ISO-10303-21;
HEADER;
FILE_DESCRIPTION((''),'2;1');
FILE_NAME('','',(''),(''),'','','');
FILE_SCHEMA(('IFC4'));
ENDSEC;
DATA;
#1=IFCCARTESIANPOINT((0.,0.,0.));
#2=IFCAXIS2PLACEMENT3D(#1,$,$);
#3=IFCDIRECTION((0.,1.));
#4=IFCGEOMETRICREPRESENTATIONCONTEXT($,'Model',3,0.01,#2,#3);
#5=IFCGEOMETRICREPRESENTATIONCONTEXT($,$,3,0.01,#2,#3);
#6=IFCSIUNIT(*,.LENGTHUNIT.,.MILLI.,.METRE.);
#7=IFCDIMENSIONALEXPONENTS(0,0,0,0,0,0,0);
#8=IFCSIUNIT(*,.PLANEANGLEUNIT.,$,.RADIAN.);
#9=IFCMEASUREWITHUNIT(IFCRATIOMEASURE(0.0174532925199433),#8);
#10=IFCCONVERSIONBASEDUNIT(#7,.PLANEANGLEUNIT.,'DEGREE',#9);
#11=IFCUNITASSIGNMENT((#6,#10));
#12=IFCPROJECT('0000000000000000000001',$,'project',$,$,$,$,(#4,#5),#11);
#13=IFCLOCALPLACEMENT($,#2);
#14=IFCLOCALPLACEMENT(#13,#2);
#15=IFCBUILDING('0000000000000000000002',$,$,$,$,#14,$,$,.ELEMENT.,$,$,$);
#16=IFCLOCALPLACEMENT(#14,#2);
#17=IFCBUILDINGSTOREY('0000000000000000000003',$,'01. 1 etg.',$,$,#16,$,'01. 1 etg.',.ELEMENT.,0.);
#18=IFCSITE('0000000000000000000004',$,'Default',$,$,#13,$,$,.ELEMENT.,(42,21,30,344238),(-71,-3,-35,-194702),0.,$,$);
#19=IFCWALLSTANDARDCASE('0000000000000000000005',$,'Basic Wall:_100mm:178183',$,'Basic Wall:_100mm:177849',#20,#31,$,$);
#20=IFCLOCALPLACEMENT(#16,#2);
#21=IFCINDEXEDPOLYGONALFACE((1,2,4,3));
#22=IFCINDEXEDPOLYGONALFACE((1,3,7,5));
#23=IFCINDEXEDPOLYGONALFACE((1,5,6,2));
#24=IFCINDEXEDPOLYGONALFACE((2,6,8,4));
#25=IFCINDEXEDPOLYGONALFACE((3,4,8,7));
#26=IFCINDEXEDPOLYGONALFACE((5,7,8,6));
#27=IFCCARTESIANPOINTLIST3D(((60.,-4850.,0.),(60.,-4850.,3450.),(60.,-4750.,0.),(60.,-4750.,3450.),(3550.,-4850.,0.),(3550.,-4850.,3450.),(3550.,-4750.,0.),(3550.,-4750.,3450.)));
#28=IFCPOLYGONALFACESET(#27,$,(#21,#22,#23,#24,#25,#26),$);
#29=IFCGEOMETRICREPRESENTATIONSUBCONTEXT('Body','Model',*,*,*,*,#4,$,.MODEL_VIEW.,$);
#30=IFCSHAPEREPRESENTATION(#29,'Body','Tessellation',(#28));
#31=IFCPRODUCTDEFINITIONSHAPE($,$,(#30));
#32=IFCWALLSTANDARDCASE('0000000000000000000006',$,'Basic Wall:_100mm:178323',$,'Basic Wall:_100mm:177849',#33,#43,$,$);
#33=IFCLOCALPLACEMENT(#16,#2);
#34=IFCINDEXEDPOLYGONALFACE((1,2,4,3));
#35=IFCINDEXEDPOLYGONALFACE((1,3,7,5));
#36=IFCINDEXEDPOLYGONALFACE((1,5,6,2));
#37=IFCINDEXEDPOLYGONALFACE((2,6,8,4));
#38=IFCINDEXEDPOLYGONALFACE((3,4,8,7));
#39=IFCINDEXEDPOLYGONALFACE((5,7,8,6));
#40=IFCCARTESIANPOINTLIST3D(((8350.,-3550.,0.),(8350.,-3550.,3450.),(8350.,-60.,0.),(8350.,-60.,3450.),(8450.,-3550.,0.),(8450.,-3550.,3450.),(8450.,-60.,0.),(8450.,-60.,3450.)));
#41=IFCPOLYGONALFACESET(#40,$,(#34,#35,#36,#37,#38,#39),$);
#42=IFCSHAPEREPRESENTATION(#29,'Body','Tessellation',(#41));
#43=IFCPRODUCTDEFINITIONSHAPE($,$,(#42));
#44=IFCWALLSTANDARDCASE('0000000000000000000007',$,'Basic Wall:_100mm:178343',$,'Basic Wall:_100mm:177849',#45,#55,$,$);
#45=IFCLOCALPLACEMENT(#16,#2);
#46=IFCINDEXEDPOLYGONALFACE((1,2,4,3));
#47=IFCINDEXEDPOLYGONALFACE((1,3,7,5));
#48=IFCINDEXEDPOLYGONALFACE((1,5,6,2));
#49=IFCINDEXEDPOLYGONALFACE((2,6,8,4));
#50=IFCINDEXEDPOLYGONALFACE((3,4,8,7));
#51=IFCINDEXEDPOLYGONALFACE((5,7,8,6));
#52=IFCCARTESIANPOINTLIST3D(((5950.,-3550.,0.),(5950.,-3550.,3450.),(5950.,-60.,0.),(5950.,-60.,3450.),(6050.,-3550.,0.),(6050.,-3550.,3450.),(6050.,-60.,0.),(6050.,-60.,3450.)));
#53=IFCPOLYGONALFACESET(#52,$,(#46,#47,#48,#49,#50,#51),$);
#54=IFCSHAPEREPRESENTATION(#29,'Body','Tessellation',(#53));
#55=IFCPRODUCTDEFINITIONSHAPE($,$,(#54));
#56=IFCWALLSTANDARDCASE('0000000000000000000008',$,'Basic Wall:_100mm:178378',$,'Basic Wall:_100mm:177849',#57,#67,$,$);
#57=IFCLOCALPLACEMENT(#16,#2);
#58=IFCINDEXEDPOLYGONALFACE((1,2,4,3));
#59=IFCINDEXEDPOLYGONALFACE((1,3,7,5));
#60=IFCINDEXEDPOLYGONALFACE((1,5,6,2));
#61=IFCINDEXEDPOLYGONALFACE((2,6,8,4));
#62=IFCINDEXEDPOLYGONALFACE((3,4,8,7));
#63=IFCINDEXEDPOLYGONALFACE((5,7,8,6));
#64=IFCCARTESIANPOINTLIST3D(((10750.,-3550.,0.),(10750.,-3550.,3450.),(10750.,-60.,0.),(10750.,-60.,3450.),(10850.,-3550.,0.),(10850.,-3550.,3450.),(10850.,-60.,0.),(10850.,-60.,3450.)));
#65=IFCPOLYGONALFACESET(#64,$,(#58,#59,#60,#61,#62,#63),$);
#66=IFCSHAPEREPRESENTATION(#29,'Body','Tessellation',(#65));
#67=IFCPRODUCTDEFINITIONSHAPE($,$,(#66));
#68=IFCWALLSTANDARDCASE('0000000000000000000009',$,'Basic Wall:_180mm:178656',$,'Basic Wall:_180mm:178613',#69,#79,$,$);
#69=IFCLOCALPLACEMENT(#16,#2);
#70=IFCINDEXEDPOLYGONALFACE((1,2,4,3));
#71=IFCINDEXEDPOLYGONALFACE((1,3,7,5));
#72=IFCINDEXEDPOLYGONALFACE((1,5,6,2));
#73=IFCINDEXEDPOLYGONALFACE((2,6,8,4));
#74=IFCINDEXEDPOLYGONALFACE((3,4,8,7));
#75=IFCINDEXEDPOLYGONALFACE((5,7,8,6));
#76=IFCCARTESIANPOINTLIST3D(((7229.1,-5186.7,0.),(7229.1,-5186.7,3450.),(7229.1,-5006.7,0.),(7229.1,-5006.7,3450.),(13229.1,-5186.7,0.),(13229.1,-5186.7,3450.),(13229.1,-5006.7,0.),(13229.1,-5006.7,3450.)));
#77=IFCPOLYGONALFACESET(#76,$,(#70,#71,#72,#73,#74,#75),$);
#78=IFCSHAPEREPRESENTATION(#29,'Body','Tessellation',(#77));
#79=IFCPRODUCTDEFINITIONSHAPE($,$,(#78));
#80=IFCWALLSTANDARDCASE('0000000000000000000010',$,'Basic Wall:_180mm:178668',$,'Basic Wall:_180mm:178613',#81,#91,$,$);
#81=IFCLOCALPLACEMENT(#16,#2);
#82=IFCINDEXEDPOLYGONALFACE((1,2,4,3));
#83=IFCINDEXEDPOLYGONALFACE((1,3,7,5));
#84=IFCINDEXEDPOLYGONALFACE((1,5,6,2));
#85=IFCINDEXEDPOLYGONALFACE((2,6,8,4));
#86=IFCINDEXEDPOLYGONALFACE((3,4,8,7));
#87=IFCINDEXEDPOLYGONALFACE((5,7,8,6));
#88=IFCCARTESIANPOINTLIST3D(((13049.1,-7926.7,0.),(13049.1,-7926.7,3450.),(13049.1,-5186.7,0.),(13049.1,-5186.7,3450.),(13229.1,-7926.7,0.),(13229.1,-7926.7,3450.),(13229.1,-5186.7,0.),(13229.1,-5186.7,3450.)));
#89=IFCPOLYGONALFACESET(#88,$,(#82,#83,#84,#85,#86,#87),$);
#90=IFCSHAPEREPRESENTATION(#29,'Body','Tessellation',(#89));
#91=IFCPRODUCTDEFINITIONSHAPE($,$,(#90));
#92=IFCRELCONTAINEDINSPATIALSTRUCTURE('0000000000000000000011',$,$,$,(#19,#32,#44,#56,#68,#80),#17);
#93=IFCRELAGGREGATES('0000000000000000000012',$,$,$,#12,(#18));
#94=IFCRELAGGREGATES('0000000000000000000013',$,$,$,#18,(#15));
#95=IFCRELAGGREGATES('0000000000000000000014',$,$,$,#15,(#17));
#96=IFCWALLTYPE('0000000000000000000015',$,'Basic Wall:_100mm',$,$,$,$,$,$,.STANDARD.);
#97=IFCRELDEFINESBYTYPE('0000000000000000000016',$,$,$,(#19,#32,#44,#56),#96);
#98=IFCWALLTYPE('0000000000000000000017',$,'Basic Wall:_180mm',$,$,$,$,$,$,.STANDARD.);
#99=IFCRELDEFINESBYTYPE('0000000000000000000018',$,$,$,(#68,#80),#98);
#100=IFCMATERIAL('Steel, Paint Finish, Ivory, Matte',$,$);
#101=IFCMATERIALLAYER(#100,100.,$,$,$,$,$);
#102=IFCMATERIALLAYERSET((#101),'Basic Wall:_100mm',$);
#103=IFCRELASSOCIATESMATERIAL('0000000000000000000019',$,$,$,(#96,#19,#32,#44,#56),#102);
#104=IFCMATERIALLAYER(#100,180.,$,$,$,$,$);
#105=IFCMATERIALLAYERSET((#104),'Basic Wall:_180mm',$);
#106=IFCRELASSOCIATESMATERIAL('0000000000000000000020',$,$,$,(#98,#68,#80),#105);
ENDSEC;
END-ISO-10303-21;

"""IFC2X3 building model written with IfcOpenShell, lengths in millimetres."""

from ifc_helpers import new_model, entity, si_unit, converted_unit, direction, frame, frame_2d, origin, place, context, subcontext, project, spatial, polyline, rectangle, extrude, clip, bounded_halfspace, material, layer, layer_set, layer_usage, type_object, element, save


model = new_model("IFC2X3")

# Units and contexts
model_context = context("Model", 3, precision=0.01, world=origin(), true_north=direction((0.0, 1.0)))
context_of_model = context(None, 3, precision=0.01, world=origin(), true_north=direction((0.0, 1.0)))
body_context = subcontext(model_context, "Body", "Model", "MODEL_VIEW")
ifc_project = project(units=[si_unit("LENGTHUNIT", "METRE", prefix="MILLI"), converted_unit("PLANEANGLEUNIT", "DEGREE", entity("IfcRatioMeasure", 0.0174532925199433), si_unit("PLANEANGLEUNIT", "RADIAN"), dimensions=[0, 0, 0, 0, 0, 0, 0])], contexts=[model_context, context_of_model])

# Site, building, storey
site_placement = place(None, origin())
site = spatial("IfcSite", under=ifc_project, at=site_placement, Name="Default", CompositionType="ELEMENT", RefLatitude=(42, 21, 30, 344238), RefLongitude=(-71, -3, -35, -194702), RefElevation=0.0)
building_placement = place(site_placement, origin())
building = spatial("IfcBuilding", under=site, at=building_placement, CompositionType="ELEMENT")
storey_placement = place(building_placement, origin())
storey = spatial("IfcBuildingStorey", under=building, at=storey_placement, Name="01. 1 etg.", LongName="01. 1 etg.", CompositionType="ELEMENT", Elevation=0.0)

# Shared definitions
ifc_material_1 = material(Name="Steel, Paint Finish, Ivory, Matte")
ifc_layer_1 = layer(ifc_material_1, 100.0)
ifc_layer_set_1 = layer_set([ifc_layer_1], Name="Basic Wall:_100mm")
wall_type_1 = type_object("IfcWallType", Name="Basic Wall:_100mm", PredefinedType="STANDARD", material=ifc_layer_set_1)

# Walls
ifc_layer_usage_1 = layer_usage(ifc_layer_set_1, "AXIS2", "NEGATIVE", 50.0)
wall_1_placement = place(storey_placement, frame((3550.0, -4800.0, 0.0), z_axis=(0.0, 0.0, 1.0), x_axis=(-1.0, 0.0, 0.0)))
element("IfcWallStandardCase", 1, at=wall_1_placement, inside=storey, type_object=wall_type_1, material=ifc_layer_usage_1, Name="Basic Wall:_100mm:178183", ObjectType="Basic Wall:_100mm:177849", context=body_context, shape_type="Clipping", body=[
    clip(extrude(rectangle(XDim=3490.0, YDim=100.0, at=frame_2d((1745.0, 0.0), x_axis=(-1.0, 0.0))), origin(), (0.0, 0.0, 1.0), 3450.0), bounded_halfspace(frame((0.0, -50.0, 3450.0), z_axis=(0.0, 0.0, -1.0), x_axis=(0.0, 1.0, 0.0)), True, frame((0.0, -50.0, 3450.0)), polyline([(0.0, 0.0), (3490.0, 0.0), (3490.0, 100.0), (0.0, 100.0), (0.0, 0.0)]))),
])
ifc_layer_usage_2 = layer_usage(ifc_layer_set_1, "AXIS2", "NEGATIVE", 50.0)
wall_2_placement = place(storey_placement, frame((8400.0, -3550.0, 0.0), z_axis=(0.0, 0.0, 1.0), x_axis=(0.0, 1.0, 0.0)))
element("IfcWallStandardCase", 2, at=wall_2_placement, inside=storey, type_object=wall_type_1, material=ifc_layer_usage_2, Name="Basic Wall:_100mm:178323", ObjectType="Basic Wall:_100mm:177849", context=body_context, shape_type="Clipping", body=[
    clip(extrude(rectangle(XDim=3490.0, YDim=100.0, at=frame_2d((1745.0, 0.0), x_axis=(-1.0, 0.0))), origin(), (0.0, 0.0, 1.0), 3450.0), bounded_halfspace(frame((0.0, -50.0, 3450.0), z_axis=(0.0, 0.0, -1.0), x_axis=(-1.0, 0.0, 0.0)), True, frame((0.0, -50.0, 3450.0)), polyline([(0.0, 0.0), (3490.0, 0.0), (3490.0, 100.0), (0.0, 100.0), (0.0, 0.0)]))),
])
ifc_layer_usage_3 = layer_usage(ifc_layer_set_1, "AXIS2", "NEGATIVE", 50.0)
wall_3_placement = place(storey_placement, frame((6000.0, -3550.0, 0.0), z_axis=(0.0, 0.0, 1.0), x_axis=(0.0, 1.0, 0.0)))
element("IfcWallStandardCase", 3, at=wall_3_placement, inside=storey, type_object=wall_type_1, material=ifc_layer_usage_3, Name="Basic Wall:_100mm:178343", ObjectType="Basic Wall:_100mm:177849", context=body_context, shape_type="Clipping", body=[
    clip(extrude(rectangle(XDim=3490.0, YDim=100.0, at=frame_2d((1745.0, 0.0), x_axis=(-1.0, 0.0))), origin(), (0.0, 0.0, 1.0), 3450.0), bounded_halfspace(frame((0.0, -50.0, 3450.0), z_axis=(0.0, 0.0, -1.0), x_axis=(-1.0, 0.0, 0.0)), True, frame((0.0, -50.0, 3450.0)), polyline([(0.0, 0.0), (3490.0, 0.0), (3490.0, 100.0), (0.0, 100.0), (0.0, 0.0)]))),
])
ifc_layer_usage_4 = layer_usage(ifc_layer_set_1, "AXIS2", "NEGATIVE", 50.0)
wall_4_placement = place(storey_placement, frame((10800.0, -3550.0, 0.0), z_axis=(0.0, 0.0, 1.0), x_axis=(0.0, 1.0, 0.0)))
element("IfcWallStandardCase", 4, at=wall_4_placement, inside=storey, type_object=wall_type_1, material=ifc_layer_usage_4, Name="Basic Wall:_100mm:178378", ObjectType="Basic Wall:_100mm:177849", context=body_context, shape_type="Clipping", body=[
    clip(extrude(rectangle(XDim=3490.0, YDim=100.0, at=frame_2d((1745.0, 0.0), x_axis=(-1.0, 0.0))), origin(), (0.0, 0.0, 1.0), 3450.0), bounded_halfspace(frame((0.0, -50.0, 3450.0), z_axis=(0.0, 0.0, -1.0), x_axis=(-1.0, 0.0, 0.0)), True, frame((0.0, -50.0, 3450.0)), polyline([(0.0, 0.0), (3490.0, 0.0), (3490.0, 100.0), (0.0, 100.0), (0.0, 0.0)]))),
])
ifc_layer_2 = layer(ifc_material_1, 180.0)
ifc_layer_set_2 = layer_set([ifc_layer_2], Name="Basic Wall:_180mm")
ifc_layer_usage_5 = layer_usage(ifc_layer_set_2, "AXIS2", "NEGATIVE", 90.0)
wall_type_2 = type_object("IfcWallType", Name="Basic Wall:_180mm", PredefinedType="STANDARD", material=ifc_layer_set_2)
wall_5_placement = place(storey_placement, frame((7229.1, -5096.7, 0.0)))
element("IfcWallStandardCase", 5, at=wall_5_placement, inside=storey, type_object=wall_type_2, material=ifc_layer_usage_5, Name="Basic Wall:_180mm:178656", ObjectType="Basic Wall:_180mm:178613", context=body_context, shape_type="Clipping", body=[
    clip(extrude(rectangle(XDim=6000.0, YDim=180.0, at=frame_2d((3000.0, 0.0), x_axis=(-1.0, 0.0))), origin(), (0.0, 0.0, 1.0), 3450.0), bounded_halfspace(frame((0.0, -90.0, 3450.0), z_axis=(0.0, 0.0, -1.0), x_axis=(0.0, -1.0, 0.0)), True, frame((0.0, -90.0, 3450.0)), polyline([(0.0, 0.0), (180.0, 0.0), (2400.0, 0.0), (2500.0, 0.0), (4022.0, 0.0), (4122.0, 0.0), (5820.0, 0.0), (6000.0, 0.0), (6000.0, 180.0), (0.0, 180.0), (0.0, 0.0)]))),
])
ifc_layer_usage_6 = layer_usage(ifc_layer_set_2, "AXIS2", "NEGATIVE", 90.0)
wall_6_placement = place(storey_placement, frame((13139.1, -5186.7, 0.0), z_axis=(0.0, 0.0, 1.0), x_axis=(0.0, -1.0, 0.0)))
element("IfcWallStandardCase", 6, at=wall_6_placement, inside=storey, type_object=wall_type_2, material=ifc_layer_usage_6, Name="Basic Wall:_180mm:178668", ObjectType="Basic Wall:_180mm:178613", context=body_context, shape_type="Clipping", body=[
    clip(extrude(rectangle(XDim=2740.0, YDim=180.0, at=frame_2d((1370.0, 0.0), x_axis=(-1.0, 0.0))), origin(), (0.0, 0.0, 1.0), 3450.0), bounded_halfspace(frame((0.0, -90.0, 3450.0), z_axis=(0.0, 0.0, -1.0), x_axis=(1.0, 0.0, 0.0)), True, frame((0.0, -90.0, 3450.0)), polyline([(0.0, 0.0), (2740.0, 0.0), (2740.0, 180.0), (0.0, 180.0), (0.0, 0.0)]))),
])

save(model, "model.ifc")
